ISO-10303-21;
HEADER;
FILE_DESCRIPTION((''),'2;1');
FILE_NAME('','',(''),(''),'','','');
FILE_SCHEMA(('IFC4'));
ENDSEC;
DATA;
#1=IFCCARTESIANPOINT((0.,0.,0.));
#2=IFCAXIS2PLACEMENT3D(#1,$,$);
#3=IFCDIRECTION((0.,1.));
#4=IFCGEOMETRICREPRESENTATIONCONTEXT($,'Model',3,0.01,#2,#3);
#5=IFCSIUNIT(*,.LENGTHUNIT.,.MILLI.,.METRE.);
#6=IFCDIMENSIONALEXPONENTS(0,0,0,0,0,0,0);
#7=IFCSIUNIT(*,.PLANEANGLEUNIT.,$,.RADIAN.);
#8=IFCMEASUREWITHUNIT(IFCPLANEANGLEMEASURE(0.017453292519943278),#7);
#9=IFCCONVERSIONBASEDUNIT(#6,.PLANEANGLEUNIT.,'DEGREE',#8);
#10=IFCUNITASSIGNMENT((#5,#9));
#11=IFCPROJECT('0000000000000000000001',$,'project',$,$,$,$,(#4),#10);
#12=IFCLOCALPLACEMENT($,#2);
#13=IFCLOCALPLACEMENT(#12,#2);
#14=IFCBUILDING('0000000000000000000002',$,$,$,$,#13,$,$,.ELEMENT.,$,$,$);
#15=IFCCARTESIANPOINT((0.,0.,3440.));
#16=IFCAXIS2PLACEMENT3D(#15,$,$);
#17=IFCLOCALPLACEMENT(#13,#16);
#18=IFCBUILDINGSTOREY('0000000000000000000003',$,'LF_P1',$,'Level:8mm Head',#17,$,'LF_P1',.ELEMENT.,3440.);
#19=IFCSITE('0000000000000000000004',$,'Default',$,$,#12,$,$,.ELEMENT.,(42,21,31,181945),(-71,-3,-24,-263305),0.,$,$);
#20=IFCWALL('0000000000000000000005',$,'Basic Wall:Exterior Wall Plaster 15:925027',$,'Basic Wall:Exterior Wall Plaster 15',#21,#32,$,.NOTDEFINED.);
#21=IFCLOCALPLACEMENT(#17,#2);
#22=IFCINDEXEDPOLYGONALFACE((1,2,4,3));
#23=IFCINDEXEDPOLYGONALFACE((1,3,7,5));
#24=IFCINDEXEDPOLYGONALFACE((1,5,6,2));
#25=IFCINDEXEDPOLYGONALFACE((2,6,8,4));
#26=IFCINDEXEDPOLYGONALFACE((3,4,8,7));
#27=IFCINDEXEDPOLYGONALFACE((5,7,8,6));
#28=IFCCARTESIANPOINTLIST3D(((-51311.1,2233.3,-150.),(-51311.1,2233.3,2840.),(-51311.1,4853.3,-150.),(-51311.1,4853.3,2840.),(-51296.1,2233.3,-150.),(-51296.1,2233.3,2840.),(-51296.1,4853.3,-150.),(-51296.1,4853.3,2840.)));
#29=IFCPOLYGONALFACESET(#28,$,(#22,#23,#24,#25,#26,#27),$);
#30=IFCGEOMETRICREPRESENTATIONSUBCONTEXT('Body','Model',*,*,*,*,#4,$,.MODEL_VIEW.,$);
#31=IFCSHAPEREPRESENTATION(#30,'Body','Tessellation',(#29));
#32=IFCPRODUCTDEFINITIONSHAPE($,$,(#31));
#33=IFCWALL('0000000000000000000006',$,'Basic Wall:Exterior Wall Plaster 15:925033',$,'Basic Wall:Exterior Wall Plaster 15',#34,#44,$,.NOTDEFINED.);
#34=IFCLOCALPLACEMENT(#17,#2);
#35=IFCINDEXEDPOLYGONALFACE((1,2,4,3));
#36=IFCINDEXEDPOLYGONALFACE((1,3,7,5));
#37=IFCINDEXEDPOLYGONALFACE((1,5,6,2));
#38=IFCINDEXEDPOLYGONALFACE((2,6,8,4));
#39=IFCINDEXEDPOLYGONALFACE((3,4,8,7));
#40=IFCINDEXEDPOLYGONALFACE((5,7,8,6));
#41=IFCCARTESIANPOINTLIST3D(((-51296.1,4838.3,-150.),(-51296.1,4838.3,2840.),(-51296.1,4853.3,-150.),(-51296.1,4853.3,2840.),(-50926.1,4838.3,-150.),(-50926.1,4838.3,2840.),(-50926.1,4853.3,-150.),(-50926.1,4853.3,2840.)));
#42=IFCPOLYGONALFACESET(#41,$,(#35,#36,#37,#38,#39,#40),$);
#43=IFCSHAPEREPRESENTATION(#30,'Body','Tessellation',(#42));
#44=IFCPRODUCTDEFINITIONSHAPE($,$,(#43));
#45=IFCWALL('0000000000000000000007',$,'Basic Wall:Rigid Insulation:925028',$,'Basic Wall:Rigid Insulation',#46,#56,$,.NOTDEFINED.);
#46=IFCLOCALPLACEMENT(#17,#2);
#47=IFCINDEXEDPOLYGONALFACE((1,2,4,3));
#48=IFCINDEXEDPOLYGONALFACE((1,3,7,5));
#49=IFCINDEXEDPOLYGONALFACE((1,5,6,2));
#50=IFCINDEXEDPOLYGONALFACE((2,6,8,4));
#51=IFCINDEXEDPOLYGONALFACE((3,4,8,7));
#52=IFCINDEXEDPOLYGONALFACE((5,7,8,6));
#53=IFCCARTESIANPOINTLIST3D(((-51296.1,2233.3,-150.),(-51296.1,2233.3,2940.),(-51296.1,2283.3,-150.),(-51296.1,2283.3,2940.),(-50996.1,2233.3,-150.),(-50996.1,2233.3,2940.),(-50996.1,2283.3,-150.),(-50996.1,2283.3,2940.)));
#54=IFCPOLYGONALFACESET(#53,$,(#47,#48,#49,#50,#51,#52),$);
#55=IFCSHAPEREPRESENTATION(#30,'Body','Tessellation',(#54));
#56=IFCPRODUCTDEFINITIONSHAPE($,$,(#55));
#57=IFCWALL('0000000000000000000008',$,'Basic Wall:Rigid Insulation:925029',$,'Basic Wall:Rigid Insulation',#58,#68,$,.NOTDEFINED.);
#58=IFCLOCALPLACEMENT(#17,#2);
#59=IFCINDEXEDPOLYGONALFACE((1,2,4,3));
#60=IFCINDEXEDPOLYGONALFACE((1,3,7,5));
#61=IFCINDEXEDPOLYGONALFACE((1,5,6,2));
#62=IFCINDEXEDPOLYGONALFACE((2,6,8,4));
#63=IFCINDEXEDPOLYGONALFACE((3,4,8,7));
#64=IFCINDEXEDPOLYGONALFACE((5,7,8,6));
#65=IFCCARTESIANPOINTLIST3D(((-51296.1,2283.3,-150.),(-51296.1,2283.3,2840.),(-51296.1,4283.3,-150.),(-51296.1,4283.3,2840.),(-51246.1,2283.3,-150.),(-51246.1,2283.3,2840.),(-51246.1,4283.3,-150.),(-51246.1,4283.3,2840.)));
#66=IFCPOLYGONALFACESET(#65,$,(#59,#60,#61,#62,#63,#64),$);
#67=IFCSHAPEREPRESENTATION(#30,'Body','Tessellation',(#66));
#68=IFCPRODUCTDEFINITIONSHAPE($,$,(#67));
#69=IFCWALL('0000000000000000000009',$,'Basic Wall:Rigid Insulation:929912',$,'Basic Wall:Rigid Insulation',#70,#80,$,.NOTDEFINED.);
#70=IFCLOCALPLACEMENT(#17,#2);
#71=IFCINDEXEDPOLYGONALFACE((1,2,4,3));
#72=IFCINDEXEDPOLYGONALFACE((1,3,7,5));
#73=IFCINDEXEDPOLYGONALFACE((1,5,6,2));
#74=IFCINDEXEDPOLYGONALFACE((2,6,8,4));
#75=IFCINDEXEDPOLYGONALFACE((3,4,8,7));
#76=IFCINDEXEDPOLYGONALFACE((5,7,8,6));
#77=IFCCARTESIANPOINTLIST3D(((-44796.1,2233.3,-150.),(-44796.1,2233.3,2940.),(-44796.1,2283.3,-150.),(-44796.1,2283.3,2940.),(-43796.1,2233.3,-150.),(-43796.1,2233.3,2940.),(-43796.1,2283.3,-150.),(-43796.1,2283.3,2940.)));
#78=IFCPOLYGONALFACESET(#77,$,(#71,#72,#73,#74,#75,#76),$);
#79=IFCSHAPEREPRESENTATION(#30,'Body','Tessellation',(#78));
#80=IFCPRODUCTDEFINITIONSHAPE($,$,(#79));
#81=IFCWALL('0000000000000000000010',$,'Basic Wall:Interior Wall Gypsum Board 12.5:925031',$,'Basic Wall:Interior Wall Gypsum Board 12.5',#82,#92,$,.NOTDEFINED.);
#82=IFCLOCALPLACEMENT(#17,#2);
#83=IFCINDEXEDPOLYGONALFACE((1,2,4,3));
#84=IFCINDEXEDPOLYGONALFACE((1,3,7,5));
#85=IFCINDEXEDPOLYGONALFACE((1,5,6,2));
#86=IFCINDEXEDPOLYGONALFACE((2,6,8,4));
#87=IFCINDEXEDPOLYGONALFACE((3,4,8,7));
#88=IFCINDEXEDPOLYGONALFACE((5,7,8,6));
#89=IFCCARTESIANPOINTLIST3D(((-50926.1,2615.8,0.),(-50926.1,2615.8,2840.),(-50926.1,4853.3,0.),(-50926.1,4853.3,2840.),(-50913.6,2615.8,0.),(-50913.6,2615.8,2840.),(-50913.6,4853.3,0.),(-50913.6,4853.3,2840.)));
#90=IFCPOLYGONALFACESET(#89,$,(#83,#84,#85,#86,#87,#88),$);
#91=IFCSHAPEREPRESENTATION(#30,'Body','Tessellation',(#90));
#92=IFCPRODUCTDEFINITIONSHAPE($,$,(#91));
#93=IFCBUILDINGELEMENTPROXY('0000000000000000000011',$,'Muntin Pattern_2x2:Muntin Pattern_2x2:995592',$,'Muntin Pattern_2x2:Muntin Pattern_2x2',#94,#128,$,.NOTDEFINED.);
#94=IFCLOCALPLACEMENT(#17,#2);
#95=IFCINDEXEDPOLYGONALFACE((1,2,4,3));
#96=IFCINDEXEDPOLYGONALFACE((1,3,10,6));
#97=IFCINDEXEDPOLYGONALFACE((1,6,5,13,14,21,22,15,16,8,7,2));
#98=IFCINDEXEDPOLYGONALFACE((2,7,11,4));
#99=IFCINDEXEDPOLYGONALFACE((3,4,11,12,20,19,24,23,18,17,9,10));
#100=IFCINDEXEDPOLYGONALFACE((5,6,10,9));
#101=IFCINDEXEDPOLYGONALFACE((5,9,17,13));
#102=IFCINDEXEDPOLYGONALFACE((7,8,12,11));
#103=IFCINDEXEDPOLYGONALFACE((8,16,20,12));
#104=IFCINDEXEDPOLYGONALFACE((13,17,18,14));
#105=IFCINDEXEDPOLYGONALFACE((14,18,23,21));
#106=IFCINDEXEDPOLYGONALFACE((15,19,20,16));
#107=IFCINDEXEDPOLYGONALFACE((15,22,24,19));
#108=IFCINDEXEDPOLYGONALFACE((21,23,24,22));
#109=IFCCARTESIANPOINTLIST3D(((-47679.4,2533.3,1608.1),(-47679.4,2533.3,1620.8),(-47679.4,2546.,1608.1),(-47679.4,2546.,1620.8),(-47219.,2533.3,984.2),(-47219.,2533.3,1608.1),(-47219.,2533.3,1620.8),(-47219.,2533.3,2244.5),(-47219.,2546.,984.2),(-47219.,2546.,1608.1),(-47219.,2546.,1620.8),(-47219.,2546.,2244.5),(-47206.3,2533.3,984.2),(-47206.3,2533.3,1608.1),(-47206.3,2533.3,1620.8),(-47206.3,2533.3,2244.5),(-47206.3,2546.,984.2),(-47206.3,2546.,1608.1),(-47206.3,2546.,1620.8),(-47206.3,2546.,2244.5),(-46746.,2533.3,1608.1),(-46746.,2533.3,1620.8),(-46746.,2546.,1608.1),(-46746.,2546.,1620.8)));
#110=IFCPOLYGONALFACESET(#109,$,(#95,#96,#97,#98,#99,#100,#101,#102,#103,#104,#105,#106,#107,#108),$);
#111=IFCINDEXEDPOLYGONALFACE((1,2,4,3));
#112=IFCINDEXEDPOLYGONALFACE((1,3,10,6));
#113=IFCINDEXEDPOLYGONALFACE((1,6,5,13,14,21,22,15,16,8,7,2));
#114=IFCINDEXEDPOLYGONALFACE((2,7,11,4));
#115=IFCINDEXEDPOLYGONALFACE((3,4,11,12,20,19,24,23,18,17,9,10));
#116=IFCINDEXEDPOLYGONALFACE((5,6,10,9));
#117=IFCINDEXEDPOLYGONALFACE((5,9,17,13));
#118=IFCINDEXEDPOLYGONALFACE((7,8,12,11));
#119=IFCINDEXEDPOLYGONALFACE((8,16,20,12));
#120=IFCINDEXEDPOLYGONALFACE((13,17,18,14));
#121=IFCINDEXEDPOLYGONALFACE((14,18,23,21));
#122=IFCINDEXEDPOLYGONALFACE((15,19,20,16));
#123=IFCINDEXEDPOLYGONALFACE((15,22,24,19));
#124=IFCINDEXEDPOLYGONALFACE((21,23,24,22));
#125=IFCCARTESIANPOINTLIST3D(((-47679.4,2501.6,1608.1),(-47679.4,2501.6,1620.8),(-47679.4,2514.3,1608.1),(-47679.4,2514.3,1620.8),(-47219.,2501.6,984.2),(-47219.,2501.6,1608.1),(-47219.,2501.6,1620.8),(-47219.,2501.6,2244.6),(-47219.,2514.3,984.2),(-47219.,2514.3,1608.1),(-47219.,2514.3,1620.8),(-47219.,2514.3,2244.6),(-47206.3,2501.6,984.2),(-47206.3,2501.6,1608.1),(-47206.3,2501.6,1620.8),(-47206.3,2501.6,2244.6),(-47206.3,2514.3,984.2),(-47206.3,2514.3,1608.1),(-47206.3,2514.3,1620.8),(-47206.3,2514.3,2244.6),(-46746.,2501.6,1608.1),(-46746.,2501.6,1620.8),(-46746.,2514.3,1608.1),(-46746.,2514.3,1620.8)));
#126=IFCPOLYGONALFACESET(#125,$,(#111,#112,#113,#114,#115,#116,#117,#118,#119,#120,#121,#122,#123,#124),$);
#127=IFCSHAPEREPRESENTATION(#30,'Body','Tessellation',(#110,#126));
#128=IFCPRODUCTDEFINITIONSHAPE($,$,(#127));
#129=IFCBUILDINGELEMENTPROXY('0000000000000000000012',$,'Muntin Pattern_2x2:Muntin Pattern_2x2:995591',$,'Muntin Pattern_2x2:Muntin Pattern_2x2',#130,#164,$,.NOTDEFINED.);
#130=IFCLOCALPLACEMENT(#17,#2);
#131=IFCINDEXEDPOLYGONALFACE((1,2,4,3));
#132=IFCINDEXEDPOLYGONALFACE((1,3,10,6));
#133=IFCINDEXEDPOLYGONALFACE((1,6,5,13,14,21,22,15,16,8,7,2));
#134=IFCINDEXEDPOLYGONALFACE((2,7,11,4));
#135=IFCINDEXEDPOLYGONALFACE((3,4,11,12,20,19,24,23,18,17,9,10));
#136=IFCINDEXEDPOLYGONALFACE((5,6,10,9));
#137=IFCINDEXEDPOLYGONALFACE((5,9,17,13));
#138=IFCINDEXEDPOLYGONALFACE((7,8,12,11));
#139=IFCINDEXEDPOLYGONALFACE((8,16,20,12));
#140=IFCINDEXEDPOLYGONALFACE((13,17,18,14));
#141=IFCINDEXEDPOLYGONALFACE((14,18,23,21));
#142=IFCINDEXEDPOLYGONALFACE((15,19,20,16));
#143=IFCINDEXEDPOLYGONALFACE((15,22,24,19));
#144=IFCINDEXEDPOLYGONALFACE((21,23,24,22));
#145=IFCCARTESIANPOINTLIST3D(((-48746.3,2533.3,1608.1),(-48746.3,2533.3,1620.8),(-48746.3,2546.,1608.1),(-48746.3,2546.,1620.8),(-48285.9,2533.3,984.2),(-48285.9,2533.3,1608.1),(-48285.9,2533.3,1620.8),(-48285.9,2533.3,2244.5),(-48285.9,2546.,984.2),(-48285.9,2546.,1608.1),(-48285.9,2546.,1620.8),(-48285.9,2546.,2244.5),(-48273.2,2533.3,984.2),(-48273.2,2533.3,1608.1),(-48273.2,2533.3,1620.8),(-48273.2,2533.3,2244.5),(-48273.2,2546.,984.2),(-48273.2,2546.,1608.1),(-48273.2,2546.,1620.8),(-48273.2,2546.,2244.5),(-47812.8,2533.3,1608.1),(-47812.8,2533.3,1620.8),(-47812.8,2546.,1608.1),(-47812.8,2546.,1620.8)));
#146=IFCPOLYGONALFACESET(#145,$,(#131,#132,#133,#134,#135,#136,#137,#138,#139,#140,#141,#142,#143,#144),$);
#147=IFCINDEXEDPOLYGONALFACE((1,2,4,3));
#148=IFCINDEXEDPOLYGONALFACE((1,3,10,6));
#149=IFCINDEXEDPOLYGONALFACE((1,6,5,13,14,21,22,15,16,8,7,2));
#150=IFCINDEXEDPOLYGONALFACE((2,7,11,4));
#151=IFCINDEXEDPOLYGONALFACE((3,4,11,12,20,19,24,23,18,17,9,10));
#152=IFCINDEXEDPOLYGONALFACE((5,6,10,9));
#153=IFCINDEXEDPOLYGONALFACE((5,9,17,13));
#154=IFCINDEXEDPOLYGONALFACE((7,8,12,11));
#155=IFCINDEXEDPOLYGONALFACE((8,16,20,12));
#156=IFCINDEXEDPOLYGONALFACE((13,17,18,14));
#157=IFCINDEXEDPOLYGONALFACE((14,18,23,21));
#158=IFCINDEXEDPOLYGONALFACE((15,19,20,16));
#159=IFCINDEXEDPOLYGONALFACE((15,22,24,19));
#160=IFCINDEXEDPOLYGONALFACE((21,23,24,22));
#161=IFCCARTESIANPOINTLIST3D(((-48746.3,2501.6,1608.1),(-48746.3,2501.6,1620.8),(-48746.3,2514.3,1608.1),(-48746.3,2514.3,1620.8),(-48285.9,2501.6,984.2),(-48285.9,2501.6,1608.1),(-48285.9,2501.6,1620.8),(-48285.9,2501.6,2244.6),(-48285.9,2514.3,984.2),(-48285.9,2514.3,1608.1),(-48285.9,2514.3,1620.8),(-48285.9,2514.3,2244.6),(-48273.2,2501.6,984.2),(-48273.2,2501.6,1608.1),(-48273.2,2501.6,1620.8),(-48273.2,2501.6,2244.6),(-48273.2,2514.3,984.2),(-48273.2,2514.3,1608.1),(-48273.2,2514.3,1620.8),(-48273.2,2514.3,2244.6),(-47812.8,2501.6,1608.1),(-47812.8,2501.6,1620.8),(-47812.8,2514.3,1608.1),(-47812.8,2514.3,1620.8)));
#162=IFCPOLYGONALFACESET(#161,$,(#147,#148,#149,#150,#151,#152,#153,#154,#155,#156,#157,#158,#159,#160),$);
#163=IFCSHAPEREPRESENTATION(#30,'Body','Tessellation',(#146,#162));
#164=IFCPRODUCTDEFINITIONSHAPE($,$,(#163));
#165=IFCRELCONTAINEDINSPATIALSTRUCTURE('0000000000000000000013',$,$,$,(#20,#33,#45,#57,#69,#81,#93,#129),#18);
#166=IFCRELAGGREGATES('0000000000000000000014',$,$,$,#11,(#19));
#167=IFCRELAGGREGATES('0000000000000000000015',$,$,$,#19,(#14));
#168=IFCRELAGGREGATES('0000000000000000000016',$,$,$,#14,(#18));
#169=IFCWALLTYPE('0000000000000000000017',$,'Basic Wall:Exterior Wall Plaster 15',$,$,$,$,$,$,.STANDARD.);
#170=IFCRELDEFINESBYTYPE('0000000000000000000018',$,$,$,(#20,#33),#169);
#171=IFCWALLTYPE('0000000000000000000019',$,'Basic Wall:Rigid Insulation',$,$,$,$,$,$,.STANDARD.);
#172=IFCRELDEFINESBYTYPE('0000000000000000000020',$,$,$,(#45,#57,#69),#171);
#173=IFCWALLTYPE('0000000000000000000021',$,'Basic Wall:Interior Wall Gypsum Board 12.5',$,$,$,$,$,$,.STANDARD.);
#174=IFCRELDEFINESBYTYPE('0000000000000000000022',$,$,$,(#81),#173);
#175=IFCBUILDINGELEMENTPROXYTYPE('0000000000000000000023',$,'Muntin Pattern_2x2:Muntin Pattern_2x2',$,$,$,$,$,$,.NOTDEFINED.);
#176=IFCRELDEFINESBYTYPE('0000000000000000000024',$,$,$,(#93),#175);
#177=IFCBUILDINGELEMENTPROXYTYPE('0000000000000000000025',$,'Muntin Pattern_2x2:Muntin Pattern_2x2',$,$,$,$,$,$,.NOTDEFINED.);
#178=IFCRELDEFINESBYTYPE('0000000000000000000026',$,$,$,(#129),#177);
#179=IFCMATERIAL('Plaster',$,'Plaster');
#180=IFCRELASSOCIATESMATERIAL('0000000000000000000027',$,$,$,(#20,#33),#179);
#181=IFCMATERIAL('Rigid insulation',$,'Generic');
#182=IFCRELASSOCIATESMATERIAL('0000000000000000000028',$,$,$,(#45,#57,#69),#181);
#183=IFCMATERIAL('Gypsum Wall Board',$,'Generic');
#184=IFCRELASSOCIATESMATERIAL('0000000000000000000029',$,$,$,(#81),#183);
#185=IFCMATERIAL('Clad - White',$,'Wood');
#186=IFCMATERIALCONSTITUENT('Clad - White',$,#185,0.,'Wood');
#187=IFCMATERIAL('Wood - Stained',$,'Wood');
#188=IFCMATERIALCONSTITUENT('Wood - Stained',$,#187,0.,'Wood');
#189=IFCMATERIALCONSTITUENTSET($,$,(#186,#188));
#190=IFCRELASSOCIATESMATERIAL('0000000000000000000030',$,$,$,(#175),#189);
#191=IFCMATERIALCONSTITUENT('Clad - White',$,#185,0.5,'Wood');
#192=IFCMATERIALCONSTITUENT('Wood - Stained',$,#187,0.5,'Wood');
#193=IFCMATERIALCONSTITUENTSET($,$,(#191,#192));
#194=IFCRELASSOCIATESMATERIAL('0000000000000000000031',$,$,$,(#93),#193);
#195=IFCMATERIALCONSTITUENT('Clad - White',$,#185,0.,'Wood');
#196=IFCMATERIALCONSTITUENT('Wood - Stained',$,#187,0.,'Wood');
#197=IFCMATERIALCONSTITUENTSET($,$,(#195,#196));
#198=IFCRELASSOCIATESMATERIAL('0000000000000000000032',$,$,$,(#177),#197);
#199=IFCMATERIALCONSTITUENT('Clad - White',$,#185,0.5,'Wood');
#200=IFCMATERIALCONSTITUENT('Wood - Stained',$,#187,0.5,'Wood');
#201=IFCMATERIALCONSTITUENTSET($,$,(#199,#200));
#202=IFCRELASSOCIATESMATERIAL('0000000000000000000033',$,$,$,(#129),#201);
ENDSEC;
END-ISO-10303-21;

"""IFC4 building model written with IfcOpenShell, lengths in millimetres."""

from ifc_helpers import new_model, entity, si_unit, converted_unit, direction, frame, origin, place, context, subcontext, project, spatial, indexed_curve, outline, extrude, source, transform, mapped, material, constituent, constituent_set, type_object, type_shapes, element, save


model = new_model("IFC4")

# Units and contexts
model_context = context("Model", 3, precision=0.01, world=origin(), true_north=direction((0.0, 1.0)))
body_context = subcontext(model_context, "Body", "Model", "MODEL_VIEW")
ifc_project = project(units=[si_unit("LENGTHUNIT", "METRE", prefix="MILLI"), converted_unit("PLANEANGLEUNIT", "DEGREE", entity("IfcPlaneAngleMeasure", 0.017453292519943278), si_unit("PLANEANGLEUNIT", "RADIAN"), dimensions=[0, 0, 0, 0, 0, 0, 0])], contexts=[model_context])

# Site, building, storey
site_placement = place(None, origin())
site = spatial("IfcSite", under=ifc_project, at=site_placement, Name="Default", CompositionType="ELEMENT", RefLatitude=(42, 21, 31, 181945), RefLongitude=(-71, -3, -24, -263305), RefElevation=0.0)
building_placement = place(site_placement, origin())
building = spatial("IfcBuilding", under=site, at=building_placement, CompositionType="ELEMENT")
storey_placement = place(building_placement, frame((0.0, 0.0, 3440.0)))
storey = spatial("IfcBuildingStorey", under=building, at=storey_placement, Name="LF_P1", ObjectType="Level:8mm Head", LongName="LF_P1", CompositionType="ELEMENT", Elevation=3440.0)

# Walls
ifc_material_1 = material(Name="Rigid insulation", Category="Generic")
ifc_material_2 = material(Name="Plaster", Category="Plaster")
wall_type_1 = type_object("IfcWallType", Name="Basic Wall:Exterior Wall Plaster 15", PredefinedType="STANDARD")
wall_1_placement = place(storey_placement, frame((-51303.6, 2233.3, -150.0), z_axis=(0.0, 0.0, 1.0), x_axis=(0.0, 1.0, 0.0)))
element("IfcWall", 1, at=wall_1_placement, inside=storey, type_object=wall_type_1, material=ifc_material_2, Name="Basic Wall:Exterior Wall Plaster 15:925027", ObjectType="Basic Wall:Exterior Wall Plaster 15", PredefinedType="NOTDEFINED", context=body_context, shape_type="SweptSolid", body=[
    extrude(outline(indexed_curve([(2620.0, 7.5), (0.0, 7.5), (0.0, -7.5), (2620.0, -7.5), (2620.0, 7.5)], self_intersect=False)), origin(), (0.0, 0.0, 1.0), 2990.0),
])
wall_2_placement = place(storey_placement, frame((-51296.1, 4845.8, -150.0)))
element("IfcWall", 2, at=wall_2_placement, inside=storey, type_object=wall_type_1, material=ifc_material_2, Name="Basic Wall:Exterior Wall Plaster 15:925033", ObjectType="Basic Wall:Exterior Wall Plaster 15", PredefinedType="NOTDEFINED", context=body_context, shape_type="SweptSolid", body=[
    extrude(outline(indexed_curve([(370.0, 7.5), (0.0, 7.5), (0.0, -7.5), (370.0, -7.5), (370.0, 7.5)], self_intersect=False)), origin(), (0.0, 0.0, 1.0), 2990.0),
])
wall_type_2 = type_object("IfcWallType", Name="Basic Wall:Rigid Insulation", PredefinedType="STANDARD")
wall_3_placement = place(storey_placement, frame((-50996.1, 2258.3, -150.0), z_axis=(0.0, 0.0, 1.0), x_axis=(-1.0, 0.0, 0.0)))
element("IfcWall", 3, at=wall_3_placement, inside=storey, type_object=wall_type_2, material=ifc_material_1, Name="Basic Wall:Rigid Insulation:925028", ObjectType="Basic Wall:Rigid Insulation", PredefinedType="NOTDEFINED", context=body_context, shape_type="SweptSolid", body=[
    extrude(outline(indexed_curve([(300.0, 25.0), (0.0, 25.0), (0.0, -25.0), (300.0, -25.0), (300.0, 25.0)], self_intersect=False)), origin(), (0.0, 0.0, 1.0), 3090.0),
])
wall_4_placement = place(storey_placement, frame((-51271.1, 2283.3, -150.0), z_axis=(0.0, 0.0, 1.0), x_axis=(0.0, 1.0, 0.0)))
element("IfcWall", 4, at=wall_4_placement, inside=storey, type_object=wall_type_2, material=ifc_material_1, Name="Basic Wall:Rigid Insulation:925029", ObjectType="Basic Wall:Rigid Insulation", PredefinedType="NOTDEFINED", context=body_context, shape_type="SweptSolid", body=[
    extrude(outline(indexed_curve([(2000.0, 25.0), (0.0, 25.0), (0.0, -25.0), (2000.0, -25.0), (2000.0, 25.0)], self_intersect=False)), origin(), (0.0, 0.0, 1.0), 2990.0),
])
wall_5_placement = place(storey_placement, frame((-44796.1, 2258.3, -150.0)))
element("IfcWall", 5, at=wall_5_placement, inside=storey, type_object=wall_type_2, material=ifc_material_1, Name="Basic Wall:Rigid Insulation:929912", ObjectType="Basic Wall:Rigid Insulation", PredefinedType="NOTDEFINED", context=body_context, shape_type="SweptSolid", body=[
    extrude(outline(indexed_curve([(1000.0, 25.0), (0.0, 25.0), (0.0, -25.0), (1000.0, -25.0), (1000.0, 25.0)], self_intersect=False)), origin(), (0.0, 0.0, 1.0), 3090.0),
])
ifc_material_3 = material(Name="Gypsum Wall Board", Category="Generic")
wall_type_3 = type_object("IfcWallType", Name="Basic Wall:Interior Wall Gypsum Board 12.5", PredefinedType="STANDARD")
wall_6_placement = place(storey_placement, frame((-50919.9, 2615.8, 0.0), z_axis=(0.0, 0.0, 1.0), x_axis=(0.0, 1.0, 0.0)))
element("IfcWall", 6, at=wall_6_placement, inside=storey, type_object=wall_type_3, material=ifc_material_3, Name="Basic Wall:Interior Wall Gypsum Board 12.5:925031", ObjectType="Basic Wall:Interior Wall Gypsum Board 12.5", PredefinedType="NOTDEFINED", context=body_context, shape_type="SweptSolid", body=[
    extrude(outline(indexed_curve([(2237.5, 6.3), (0.0, 6.3), (0.0, -6.3), (2237.5, -6.3), (2237.5, 6.3)], self_intersect=False)), origin(), (0.0, 0.0, 1.0), 2840.0),
])

# Building element proxies
ifc_material_4 = material(Name="Clad - White", Category="Wood")
ifc_constituent_1 = constituent(ifc_material_4, Name="Clad - White", Category="Wood", fraction=0.5)
ifc_material_5 = material(Name="Wood - Stained", Category="Wood")
ifc_constituent_2 = constituent(ifc_material_5, Name="Wood - Stained", Category="Wood", fraction=0.5)
ifc_constituent_set_1 = constituent_set(constituents=[ifc_constituent_1, ifc_constituent_2])
ifc_constituent_3 = constituent(ifc_material_4, Name="Clad - White", Category="Wood", fraction=0.0)
ifc_constituent_4 = constituent(ifc_material_5, Name="Wood - Stained", Category="Wood", fraction=0.0)
ifc_constituent_set_2 = constituent_set(constituents=[ifc_constituent_3, ifc_constituent_4])
building_element_proxy_type_1 = type_object("IfcBuildingElementProxyType", Name="Muntin Pattern_2x2:Muntin Pattern_2x2", PredefinedType="NOTDEFINED", material=ifc_constituent_set_2)
shared_shape_1 = source(origin(), body_context, "Body", "SweptSolid", [
    extrude(outline(indexed_curve([(6.4, -6.4), (630.1, -6.4), (630.1, 6.3), (6.4, 6.3), (6.4, 466.7), (-6.3, 466.7), (-6.3, 6.3), (-630.2, 6.3), (-630.2, -6.4), (-6.3, -6.4), (-6.3, -466.7), (6.4, -466.7), (6.4, -6.4)], self_intersect=False)), frame((0.0, -22.2, 630.1), z_axis=(0.0, 1.0, 0.0), x_axis=(0.0, 0.0, 1.0)), (0.0, 0.0, 1.0), 12.7),
    extrude(outline(indexed_curve([(6.4, -6.4), (630.2, -6.4), (630.2, 6.3), (6.4, 6.3), (6.4, 466.7), (-6.3, 466.7), (-6.3, 6.3), (-630.2, 6.3), (-630.2, -6.4), (-6.3, -6.4), (-6.3, -466.7), (6.4, -466.7), (6.4, -6.4)], self_intersect=False)), frame((0.0, 9.5, 630.2), z_axis=(0.0, 1.0, 0.0), x_axis=(0.0, 0.0, 1.0)), (0.0, 0.0, 1.0), 12.7),
])
type_shapes(building_element_proxy_type_1, [shared_shape_1])
proxy_1_placement = place(storey_placement, frame((-47212.7, 2523.8, 984.3), z_axis=(0.0, 0.0, 1.0), x_axis=(-1.0, 0.0, 0.0)))
element("IfcBuildingElementProxy", 7, at=proxy_1_placement, inside=storey, type_object=building_element_proxy_type_1, material=ifc_constituent_set_1, Name="Muntin Pattern_2x2:Muntin Pattern_2x2:995592", ObjectType="Muntin Pattern_2x2:Muntin Pattern_2x2", PredefinedType="NOTDEFINED", context=body_context, shape_type="MappedRepresentation", body=[
    mapped(shared_shape_1, transform((0.0, 0.0, 0.0), scale=1.0)),
])
ifc_constituent_5 = constituent(ifc_material_4, Name="Clad - White", Category="Wood", fraction=0.5)
ifc_constituent_6 = constituent(ifc_material_5, Name="Wood - Stained", Category="Wood", fraction=0.5)
ifc_constituent_set_3 = constituent_set(constituents=[ifc_constituent_5, ifc_constituent_6])
ifc_constituent_7 = constituent(ifc_material_4, Name="Clad - White", Category="Wood", fraction=0.0)
ifc_constituent_8 = constituent(ifc_material_5, Name="Wood - Stained", Category="Wood", fraction=0.0)
ifc_constituent_set_4 = constituent_set(constituents=[ifc_constituent_7, ifc_constituent_8])
building_element_proxy_type_2 = type_object("IfcBuildingElementProxyType", Name="Muntin Pattern_2x2:Muntin Pattern_2x2", PredefinedType="NOTDEFINED", material=ifc_constituent_set_4)
shared_shape_2 = source(origin(), body_context, "Body", "SweptSolid", [
    extrude(outline(indexed_curve([(6.4, -6.4), (630.1, -6.4), (630.1, 6.3), (6.4, 6.3), (6.4, 466.7), (-6.3, 466.7), (-6.3, 6.3), (-630.2, 6.3), (-630.2, -6.4), (-6.3, -6.4), (-6.3, -466.7), (6.4, -466.7), (6.4, -6.4)], self_intersect=False)), frame((0.0, 9.5, 630.1), z_axis=(0.0, 1.0, 0.0), x_axis=(0.0, 0.0, 1.0)), (0.0, 0.0, 1.0), 12.7),
    extrude(outline(indexed_curve([(6.4, -6.4), (630.2, -6.4), (630.2, 6.3), (6.4, 6.3), (6.4, 466.7), (-6.3, 466.7), (-6.3, 6.3), (-630.2, 6.3), (-630.2, -6.4), (-6.3, -6.4), (-6.3, -466.7), (6.4, -466.7), (6.4, -6.4)], self_intersect=False)), frame((0.0, -22.2, 630.2), z_axis=(0.0, 1.0, 0.0), x_axis=(0.0, 0.0, 1.0)), (0.0, 0.0, 1.0), 12.7),
])
type_shapes(building_element_proxy_type_2, [shared_shape_2])
proxy_2_placement = place(storey_placement, frame((-48279.5, 2523.8, 984.3)))
element("IfcBuildingElementProxy", 8, at=proxy_2_placement, inside=storey, type_object=building_element_proxy_type_2, material=ifc_constituent_set_3, Name="Muntin Pattern_2x2:Muntin Pattern_2x2:995591", ObjectType="Muntin Pattern_2x2:Muntin Pattern_2x2", PredefinedType="NOTDEFINED", context=body_context, shape_type="MappedRepresentation", body=[
    mapped(shared_shape_2, transform((0.0, 0.0, 0.0), scale=1.0)),
])

save(model, "model.ifc")
